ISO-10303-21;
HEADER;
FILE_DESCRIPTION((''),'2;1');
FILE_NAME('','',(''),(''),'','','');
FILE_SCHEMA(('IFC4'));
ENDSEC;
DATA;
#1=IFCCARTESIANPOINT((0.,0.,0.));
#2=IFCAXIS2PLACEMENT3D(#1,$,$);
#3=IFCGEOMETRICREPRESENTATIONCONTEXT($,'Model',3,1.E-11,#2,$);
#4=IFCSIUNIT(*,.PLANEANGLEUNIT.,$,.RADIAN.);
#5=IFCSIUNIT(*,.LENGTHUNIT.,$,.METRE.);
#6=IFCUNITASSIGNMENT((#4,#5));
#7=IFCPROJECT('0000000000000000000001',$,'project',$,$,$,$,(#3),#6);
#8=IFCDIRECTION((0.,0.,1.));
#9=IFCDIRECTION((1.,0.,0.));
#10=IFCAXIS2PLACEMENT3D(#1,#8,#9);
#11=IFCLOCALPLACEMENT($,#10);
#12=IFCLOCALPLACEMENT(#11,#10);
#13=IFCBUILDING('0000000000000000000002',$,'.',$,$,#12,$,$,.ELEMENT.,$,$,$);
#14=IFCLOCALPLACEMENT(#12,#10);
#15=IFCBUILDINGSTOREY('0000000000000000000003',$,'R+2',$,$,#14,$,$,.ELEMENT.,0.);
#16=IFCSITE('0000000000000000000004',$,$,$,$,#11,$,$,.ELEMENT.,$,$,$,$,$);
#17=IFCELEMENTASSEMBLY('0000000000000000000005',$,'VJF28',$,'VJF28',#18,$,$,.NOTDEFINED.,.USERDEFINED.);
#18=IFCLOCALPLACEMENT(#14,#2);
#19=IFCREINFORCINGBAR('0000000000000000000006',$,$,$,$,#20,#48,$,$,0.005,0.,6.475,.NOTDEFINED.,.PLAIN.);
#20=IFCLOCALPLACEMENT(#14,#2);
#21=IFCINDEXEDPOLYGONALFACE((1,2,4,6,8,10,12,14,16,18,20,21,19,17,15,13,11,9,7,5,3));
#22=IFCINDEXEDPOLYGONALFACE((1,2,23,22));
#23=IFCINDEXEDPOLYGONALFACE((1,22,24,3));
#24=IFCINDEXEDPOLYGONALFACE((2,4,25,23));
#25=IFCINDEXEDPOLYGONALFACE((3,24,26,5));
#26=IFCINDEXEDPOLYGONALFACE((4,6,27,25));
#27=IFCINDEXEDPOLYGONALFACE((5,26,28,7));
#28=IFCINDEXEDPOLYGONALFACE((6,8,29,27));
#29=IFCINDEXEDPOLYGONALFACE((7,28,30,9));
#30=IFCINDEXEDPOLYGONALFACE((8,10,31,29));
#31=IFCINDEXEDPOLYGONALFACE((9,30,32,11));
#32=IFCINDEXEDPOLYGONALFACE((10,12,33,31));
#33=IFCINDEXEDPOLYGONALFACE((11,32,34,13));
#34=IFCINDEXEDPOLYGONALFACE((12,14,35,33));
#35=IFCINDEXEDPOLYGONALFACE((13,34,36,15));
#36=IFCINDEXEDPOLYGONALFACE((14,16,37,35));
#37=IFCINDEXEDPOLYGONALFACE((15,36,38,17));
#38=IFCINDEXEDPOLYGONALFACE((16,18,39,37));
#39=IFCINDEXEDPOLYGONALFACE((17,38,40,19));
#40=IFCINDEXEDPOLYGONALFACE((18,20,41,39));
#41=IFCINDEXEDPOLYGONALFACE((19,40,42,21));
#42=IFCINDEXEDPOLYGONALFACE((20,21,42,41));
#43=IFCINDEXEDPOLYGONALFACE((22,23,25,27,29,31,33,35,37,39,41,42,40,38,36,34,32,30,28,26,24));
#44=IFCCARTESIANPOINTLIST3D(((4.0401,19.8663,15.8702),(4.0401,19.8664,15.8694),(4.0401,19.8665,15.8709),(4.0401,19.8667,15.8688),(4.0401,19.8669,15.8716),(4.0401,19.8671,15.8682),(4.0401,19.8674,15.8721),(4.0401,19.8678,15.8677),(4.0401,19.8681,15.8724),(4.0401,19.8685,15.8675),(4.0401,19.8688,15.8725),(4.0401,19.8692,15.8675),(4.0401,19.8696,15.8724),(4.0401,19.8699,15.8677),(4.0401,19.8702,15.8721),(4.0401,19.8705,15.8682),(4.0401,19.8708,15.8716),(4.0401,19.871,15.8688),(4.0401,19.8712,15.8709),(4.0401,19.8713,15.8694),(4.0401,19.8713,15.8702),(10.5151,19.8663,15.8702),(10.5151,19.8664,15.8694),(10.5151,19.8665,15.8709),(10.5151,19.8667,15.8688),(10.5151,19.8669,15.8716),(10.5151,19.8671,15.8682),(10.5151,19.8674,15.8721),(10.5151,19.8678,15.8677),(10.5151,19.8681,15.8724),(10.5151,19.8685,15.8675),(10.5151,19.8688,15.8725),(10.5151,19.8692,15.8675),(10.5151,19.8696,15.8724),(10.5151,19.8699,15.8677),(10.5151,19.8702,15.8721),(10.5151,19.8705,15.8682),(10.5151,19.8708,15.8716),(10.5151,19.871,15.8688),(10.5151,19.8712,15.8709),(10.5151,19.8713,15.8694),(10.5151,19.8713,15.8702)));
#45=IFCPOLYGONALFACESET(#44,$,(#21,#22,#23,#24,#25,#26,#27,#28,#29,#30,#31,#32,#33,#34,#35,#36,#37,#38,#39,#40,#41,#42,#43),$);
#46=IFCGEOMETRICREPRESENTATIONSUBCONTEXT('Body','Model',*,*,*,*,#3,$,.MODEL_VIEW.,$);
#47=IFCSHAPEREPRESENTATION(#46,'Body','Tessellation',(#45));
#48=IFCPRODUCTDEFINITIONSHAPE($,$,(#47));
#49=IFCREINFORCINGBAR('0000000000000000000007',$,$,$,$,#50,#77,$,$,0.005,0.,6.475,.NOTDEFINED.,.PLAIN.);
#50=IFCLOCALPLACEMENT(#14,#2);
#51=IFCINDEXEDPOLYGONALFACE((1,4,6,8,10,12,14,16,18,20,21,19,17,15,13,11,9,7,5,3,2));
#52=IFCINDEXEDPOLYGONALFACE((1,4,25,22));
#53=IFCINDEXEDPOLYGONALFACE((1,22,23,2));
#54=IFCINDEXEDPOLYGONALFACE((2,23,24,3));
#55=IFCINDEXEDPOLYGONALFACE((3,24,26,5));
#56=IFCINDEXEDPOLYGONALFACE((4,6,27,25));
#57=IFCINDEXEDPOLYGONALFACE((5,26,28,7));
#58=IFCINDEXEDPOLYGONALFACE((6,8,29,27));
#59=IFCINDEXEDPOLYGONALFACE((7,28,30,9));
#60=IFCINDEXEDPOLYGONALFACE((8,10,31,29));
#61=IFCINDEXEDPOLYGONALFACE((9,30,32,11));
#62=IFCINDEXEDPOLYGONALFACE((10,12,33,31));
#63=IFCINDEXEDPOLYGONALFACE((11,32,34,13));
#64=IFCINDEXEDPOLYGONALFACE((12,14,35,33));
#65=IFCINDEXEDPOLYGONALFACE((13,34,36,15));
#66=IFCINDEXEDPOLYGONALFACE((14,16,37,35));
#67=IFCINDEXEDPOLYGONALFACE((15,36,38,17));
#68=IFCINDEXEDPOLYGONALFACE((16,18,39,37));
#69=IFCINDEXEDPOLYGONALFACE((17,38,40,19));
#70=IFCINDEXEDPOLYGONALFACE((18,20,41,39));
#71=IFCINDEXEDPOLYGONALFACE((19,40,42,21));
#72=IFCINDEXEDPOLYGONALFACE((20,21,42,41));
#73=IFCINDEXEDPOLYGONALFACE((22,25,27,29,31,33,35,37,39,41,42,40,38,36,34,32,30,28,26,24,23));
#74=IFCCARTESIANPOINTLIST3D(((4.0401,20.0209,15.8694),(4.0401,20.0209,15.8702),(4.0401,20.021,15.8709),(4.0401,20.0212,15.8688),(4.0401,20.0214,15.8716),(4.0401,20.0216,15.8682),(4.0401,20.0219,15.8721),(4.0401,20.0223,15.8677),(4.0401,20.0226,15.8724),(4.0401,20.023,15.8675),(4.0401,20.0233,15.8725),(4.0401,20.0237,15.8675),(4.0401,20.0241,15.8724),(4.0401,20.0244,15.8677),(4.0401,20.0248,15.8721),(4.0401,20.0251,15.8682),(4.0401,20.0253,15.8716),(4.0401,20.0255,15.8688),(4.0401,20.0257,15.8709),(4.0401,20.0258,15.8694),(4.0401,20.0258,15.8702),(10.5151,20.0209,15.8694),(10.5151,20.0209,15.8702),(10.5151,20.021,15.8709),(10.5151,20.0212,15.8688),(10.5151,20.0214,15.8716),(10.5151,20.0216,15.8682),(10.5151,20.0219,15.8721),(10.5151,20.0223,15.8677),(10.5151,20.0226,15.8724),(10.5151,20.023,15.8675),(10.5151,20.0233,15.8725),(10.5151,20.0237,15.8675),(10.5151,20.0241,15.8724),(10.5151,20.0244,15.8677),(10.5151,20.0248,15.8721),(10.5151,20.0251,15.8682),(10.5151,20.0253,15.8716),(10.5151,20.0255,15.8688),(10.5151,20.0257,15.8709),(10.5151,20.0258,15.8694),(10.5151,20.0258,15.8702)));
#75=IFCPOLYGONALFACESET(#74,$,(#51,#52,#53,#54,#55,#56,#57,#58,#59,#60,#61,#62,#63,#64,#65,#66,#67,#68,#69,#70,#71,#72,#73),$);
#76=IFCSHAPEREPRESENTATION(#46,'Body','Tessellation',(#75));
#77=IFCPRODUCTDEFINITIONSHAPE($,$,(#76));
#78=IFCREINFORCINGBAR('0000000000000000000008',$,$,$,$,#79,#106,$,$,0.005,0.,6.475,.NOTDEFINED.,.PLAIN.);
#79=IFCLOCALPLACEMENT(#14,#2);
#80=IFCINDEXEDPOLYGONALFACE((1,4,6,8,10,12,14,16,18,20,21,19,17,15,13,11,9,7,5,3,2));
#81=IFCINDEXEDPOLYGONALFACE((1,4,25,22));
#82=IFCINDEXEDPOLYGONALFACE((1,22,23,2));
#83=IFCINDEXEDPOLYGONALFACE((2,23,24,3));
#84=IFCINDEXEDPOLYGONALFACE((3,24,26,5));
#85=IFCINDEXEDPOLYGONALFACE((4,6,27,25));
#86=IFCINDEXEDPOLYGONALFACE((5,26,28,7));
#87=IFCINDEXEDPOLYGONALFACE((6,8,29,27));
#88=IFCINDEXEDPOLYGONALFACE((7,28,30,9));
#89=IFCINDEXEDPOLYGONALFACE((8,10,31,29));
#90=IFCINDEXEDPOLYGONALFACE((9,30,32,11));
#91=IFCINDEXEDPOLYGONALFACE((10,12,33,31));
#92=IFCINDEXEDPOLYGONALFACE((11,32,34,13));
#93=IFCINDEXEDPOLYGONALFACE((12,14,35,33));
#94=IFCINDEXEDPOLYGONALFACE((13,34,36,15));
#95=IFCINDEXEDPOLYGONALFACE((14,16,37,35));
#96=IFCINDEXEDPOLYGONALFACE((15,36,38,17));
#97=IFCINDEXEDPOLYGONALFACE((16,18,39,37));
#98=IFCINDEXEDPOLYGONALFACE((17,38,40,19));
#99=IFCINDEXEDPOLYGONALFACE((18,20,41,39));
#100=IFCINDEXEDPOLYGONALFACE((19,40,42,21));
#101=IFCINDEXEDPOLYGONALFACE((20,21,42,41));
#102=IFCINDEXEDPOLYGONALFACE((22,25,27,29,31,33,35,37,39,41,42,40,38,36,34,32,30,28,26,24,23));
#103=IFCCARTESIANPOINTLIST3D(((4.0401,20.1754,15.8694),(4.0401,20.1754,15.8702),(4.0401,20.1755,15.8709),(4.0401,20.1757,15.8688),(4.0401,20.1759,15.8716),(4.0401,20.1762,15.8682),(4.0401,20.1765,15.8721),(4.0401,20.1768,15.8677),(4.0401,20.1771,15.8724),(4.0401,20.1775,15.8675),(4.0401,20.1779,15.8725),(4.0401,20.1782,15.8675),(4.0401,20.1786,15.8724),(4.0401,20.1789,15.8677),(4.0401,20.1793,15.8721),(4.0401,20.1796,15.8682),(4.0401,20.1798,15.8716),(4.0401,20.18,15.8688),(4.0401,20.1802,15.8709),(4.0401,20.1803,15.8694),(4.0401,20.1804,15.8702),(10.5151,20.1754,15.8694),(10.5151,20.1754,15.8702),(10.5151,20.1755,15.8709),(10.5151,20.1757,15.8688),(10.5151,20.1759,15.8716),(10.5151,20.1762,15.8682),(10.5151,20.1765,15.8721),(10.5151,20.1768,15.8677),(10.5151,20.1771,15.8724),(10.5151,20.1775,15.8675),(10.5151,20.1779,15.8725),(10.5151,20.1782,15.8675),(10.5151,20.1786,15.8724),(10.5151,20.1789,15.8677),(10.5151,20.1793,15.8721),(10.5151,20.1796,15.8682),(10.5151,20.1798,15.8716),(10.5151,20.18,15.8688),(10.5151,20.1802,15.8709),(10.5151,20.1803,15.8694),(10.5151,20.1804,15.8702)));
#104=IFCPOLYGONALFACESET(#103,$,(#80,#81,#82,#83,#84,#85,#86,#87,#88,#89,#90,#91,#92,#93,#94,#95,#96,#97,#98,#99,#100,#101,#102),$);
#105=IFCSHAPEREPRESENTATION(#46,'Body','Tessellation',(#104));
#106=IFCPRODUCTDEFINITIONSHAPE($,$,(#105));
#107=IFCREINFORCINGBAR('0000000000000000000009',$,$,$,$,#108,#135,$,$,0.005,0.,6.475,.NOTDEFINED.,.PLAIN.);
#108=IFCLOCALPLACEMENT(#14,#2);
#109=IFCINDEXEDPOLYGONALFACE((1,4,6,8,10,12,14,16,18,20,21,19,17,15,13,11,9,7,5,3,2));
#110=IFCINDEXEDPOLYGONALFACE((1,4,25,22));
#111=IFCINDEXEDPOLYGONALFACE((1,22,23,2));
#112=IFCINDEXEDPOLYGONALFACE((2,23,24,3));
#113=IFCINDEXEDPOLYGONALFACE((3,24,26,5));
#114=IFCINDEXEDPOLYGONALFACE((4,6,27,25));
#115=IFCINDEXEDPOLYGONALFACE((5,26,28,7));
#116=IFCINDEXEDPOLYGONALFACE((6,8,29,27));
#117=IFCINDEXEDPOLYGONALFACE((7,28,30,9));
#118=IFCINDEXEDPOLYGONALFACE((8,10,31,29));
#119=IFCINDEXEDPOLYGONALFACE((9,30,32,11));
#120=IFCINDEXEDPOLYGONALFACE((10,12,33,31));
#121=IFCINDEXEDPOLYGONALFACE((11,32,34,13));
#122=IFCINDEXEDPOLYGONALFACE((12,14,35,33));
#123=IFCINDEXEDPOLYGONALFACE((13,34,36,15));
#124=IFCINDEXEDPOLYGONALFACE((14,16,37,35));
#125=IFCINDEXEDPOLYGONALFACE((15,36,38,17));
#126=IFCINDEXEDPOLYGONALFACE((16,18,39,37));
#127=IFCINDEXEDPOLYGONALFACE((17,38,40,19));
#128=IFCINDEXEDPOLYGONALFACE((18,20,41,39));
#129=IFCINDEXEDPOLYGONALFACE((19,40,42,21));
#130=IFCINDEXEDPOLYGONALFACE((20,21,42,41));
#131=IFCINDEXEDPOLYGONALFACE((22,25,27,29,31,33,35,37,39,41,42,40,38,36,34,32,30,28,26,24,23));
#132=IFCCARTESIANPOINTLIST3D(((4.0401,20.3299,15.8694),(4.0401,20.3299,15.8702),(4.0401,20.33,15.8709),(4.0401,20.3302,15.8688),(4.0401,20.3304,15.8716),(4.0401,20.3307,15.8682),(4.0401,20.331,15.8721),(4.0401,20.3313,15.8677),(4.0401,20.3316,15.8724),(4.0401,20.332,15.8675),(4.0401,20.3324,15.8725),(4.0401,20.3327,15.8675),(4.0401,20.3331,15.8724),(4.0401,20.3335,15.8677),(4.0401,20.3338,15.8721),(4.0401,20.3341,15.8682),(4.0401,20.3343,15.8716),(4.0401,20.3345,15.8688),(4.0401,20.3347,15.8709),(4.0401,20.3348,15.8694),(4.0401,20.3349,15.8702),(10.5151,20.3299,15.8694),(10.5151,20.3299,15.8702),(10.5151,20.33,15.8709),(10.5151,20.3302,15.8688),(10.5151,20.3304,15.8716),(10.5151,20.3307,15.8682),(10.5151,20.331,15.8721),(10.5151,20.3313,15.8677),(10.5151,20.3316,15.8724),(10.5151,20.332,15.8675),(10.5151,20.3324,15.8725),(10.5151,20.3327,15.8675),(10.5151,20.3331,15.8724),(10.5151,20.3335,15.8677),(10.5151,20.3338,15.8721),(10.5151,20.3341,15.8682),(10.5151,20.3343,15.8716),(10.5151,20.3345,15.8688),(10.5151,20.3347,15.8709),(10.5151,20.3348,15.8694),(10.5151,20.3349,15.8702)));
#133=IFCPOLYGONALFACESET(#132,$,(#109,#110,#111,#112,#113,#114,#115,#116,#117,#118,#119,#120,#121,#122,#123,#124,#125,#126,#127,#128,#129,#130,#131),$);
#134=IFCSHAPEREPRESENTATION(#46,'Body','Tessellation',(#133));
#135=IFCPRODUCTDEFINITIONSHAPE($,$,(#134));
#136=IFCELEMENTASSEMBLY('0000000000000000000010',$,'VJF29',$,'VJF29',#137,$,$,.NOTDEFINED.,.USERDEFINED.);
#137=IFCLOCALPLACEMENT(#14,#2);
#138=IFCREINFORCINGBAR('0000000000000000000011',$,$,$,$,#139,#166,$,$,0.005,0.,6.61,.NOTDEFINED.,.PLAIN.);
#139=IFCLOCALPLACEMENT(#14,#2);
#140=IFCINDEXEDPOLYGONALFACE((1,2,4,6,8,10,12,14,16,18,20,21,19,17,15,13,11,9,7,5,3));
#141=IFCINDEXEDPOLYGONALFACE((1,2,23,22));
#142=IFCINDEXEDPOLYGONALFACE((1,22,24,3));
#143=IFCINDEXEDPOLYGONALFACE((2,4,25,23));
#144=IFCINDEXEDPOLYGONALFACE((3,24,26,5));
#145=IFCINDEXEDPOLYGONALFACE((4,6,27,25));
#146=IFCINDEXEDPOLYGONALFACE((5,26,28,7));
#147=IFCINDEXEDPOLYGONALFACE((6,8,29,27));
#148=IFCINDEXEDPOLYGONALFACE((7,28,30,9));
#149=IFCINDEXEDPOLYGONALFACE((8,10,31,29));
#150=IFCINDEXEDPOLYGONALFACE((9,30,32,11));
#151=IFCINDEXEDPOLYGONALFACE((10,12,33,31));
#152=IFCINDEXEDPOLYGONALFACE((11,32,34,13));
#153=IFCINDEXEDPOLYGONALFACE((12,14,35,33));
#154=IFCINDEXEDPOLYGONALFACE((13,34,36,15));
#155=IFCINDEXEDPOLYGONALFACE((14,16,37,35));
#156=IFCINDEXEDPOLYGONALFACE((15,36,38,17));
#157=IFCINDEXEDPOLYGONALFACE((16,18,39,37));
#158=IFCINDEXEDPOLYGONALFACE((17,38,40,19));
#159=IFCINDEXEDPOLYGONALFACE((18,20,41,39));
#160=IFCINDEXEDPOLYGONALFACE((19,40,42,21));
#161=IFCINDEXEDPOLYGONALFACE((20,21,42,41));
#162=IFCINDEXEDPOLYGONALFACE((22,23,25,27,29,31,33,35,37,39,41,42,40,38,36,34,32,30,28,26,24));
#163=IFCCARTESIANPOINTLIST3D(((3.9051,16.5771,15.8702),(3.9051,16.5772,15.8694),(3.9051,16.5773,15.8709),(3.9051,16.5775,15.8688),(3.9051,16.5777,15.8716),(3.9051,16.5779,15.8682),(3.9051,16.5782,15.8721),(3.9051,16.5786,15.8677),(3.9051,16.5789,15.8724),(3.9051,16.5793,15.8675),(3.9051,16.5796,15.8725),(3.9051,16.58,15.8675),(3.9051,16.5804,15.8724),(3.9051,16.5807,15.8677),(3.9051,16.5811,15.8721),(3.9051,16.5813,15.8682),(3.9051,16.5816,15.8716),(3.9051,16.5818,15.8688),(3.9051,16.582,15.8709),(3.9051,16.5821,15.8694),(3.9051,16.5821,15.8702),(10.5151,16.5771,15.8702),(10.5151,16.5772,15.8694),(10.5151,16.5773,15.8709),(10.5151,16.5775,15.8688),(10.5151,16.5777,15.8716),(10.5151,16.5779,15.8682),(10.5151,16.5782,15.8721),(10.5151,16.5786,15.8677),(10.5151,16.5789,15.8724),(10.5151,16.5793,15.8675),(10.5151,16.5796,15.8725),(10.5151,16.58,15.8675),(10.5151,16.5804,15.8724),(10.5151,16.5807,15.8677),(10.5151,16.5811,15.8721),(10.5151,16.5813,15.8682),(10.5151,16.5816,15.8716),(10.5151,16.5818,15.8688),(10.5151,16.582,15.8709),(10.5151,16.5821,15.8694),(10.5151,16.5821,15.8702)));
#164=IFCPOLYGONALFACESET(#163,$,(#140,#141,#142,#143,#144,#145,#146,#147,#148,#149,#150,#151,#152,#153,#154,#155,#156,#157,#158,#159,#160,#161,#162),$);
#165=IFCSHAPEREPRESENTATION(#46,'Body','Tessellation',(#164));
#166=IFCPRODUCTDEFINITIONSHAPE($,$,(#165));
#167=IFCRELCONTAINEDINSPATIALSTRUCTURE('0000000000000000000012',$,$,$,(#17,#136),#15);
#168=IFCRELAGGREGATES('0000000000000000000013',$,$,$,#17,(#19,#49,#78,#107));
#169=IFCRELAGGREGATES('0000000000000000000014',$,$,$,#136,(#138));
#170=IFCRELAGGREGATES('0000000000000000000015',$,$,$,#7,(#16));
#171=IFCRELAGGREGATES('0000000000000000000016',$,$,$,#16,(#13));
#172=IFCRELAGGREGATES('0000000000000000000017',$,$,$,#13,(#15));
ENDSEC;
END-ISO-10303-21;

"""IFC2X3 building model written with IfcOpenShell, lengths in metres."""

from ifc_helpers import new_model, entity, si_unit, origin, origin_with_axes, place, context, subcontext, project, spatial, shape, element, aggregate, save


model = new_model("IFC2X3")

# Units and contexts
model_context = context("Model", 3, precision=1e-11, world=origin())
body_context = subcontext(model_context, "Body", "Model", "MODEL_VIEW")
ifc_project = project(units=[si_unit("PLANEANGLEUNIT", "RADIAN"), si_unit("LENGTHUNIT", "METRE")], contexts=[model_context])

# Site, building, storey
site_placement = place(None, origin_with_axes())
site = spatial("IfcSite", under=ifc_project, at=site_placement, CompositionType="ELEMENT")
building_placement = place(site_placement, origin_with_axes())
building = spatial("IfcBuilding", under=site, at=building_placement, Name=".", CompositionType="ELEMENT")
storey_placement = place(building_placement, origin_with_axes())
storey = spatial("IfcBuildingStorey", under=building, at=storey_placement, Name="R+2", CompositionType="ELEMENT", Elevation=0.0)

# Element assemblies, reinforcing bars
assembly_1_placement = place(storey_placement, origin_with_axes())
assembly_1 = element("IfcElementAssembly", 1, at=assembly_1_placement, inside=storey, Name="VJF28", ObjectType="VJF28", AssemblyPlace="NOTDEFINED", PredefinedType="USERDEFINED")
reinforcing_bar_1_placement = place(assembly_1_placement, origin_with_axes())
reinforcing_bar_1 = element("IfcReinforcingBar", 2, at=reinforcing_bar_1_placement, BarLength=6.475, BarRole="NOTDEFINED", BarSurface="PLAIN", CrossSectionArea=0.0, NominalDiameter=0.005, shapes=[
    shape(body_context, "Body", "AdvancedSweptSolid", [entity("IfcSweptDiskSolid", entity("IfcPolyline", [entity("IfcCartesianPoint", [4.0401, 19.8688, 15.87]), entity("IfcCartesianPoint", [10.5151, 19.8688, 15.87])]), 0.0025, None, 0.0, 6.475)]),
    shape(body_context, "Body", "AdvancedSweptSolid", [entity("IfcSweptDiskSolid", entity("IfcPolyline", [entity("IfcCartesianPoint", [4.0401, 19.8688, 15.87]), entity("IfcCartesianPoint", [10.5151, 19.8688, 15.87])]), 0.0025, None, 0.0, 6.475)]),
])
reinforcing_bar_2_placement = place(assembly_1_placement, origin_with_axes())
reinforcing_bar_2 = element("IfcReinforcingBar", 3, at=reinforcing_bar_2_placement, BarLength=6.475, BarRole="NOTDEFINED", BarSurface="PLAIN", CrossSectionArea=0.0, NominalDiameter=0.005, shapes=[
    shape(body_context, "Body", "AdvancedSweptSolid", [entity("IfcSweptDiskSolid", entity("IfcPolyline", [entity("IfcCartesianPoint", [4.0401, 20.0233, 15.87]), entity("IfcCartesianPoint", [10.5151, 20.0233, 15.87])]), 0.0025, None, 0.0, 6.475)]),
    shape(body_context, "Body", "AdvancedSweptSolid", [entity("IfcSweptDiskSolid", entity("IfcPolyline", [entity("IfcCartesianPoint", [4.0401, 20.0233, 15.87]), entity("IfcCartesianPoint", [10.5151, 20.0233, 15.87])]), 0.0025, None, 0.0, 6.475)]),
])
reinforcing_bar_3_placement = place(assembly_1_placement, origin_with_axes())
reinforcing_bar_3 = element("IfcReinforcingBar", 4, at=reinforcing_bar_3_placement, BarLength=6.475, BarRole="NOTDEFINED", BarSurface="PLAIN", CrossSectionArea=0.0, NominalDiameter=0.005, shapes=[
    shape(body_context, "Body", "AdvancedSweptSolid", [entity("IfcSweptDiskSolid", entity("IfcPolyline", [entity("IfcCartesianPoint", [4.0401, 20.1779, 15.87]), entity("IfcCartesianPoint", [10.5151, 20.1779, 15.87])]), 0.0025, None, 0.0, 6.475)]),
    shape(body_context, "Body", "AdvancedSweptSolid", [entity("IfcSweptDiskSolid", entity("IfcPolyline", [entity("IfcCartesianPoint", [4.0401, 20.1779, 15.87]), entity("IfcCartesianPoint", [10.5151, 20.1779, 15.87])]), 0.0025, None, 0.0, 6.475)]),
])
reinforcing_bar_4_placement = place(assembly_1_placement, origin_with_axes())
reinforcing_bar_4 = element("IfcReinforcingBar", 5, at=reinforcing_bar_4_placement, BarLength=6.475, BarRole="NOTDEFINED", BarSurface="PLAIN", CrossSectionArea=0.0, NominalDiameter=0.005, shapes=[
    shape(body_context, "Body", "AdvancedSweptSolid", [entity("IfcSweptDiskSolid", entity("IfcPolyline", [entity("IfcCartesianPoint", [4.0401, 20.3324, 15.87]), entity("IfcCartesianPoint", [10.5151, 20.3324, 15.87])]), 0.0025, None, 0.0, 6.475)]),
    shape(body_context, "Body", "AdvancedSweptSolid", [entity("IfcSweptDiskSolid", entity("IfcPolyline", [entity("IfcCartesianPoint", [4.0401, 20.3324, 15.87]), entity("IfcCartesianPoint", [10.5151, 20.3324, 15.87])]), 0.0025, None, 0.0, 6.475)]),
])
aggregate(assembly_1, [reinforcing_bar_1, reinforcing_bar_2, reinforcing_bar_3, reinforcing_bar_4])
assembly_2_placement = place(storey_placement, origin_with_axes())
assembly_2 = element("IfcElementAssembly", 6, at=assembly_2_placement, inside=storey, Name="VJF29", ObjectType="VJF29", AssemblyPlace="NOTDEFINED", PredefinedType="USERDEFINED")
reinforcing_bar_5_placement = place(assembly_2_placement, origin_with_axes())
reinforcing_bar_5 = element("IfcReinforcingBar", 7, at=reinforcing_bar_5_placement, BarLength=6.61, BarRole="NOTDEFINED", BarSurface="PLAIN", CrossSectionArea=0.0, NominalDiameter=0.005, shapes=[
    shape(body_context, "Body", "AdvancedSweptSolid", [entity("IfcSweptDiskSolid", entity("IfcPolyline", [entity("IfcCartesianPoint", [3.9051, 16.5796, 15.87]), entity("IfcCartesianPoint", [10.5151, 16.5796, 15.87])]), 0.0025, None, 0.0, 6.61)]),
    shape(body_context, "Body", "AdvancedSweptSolid", [entity("IfcSweptDiskSolid", entity("IfcPolyline", [entity("IfcCartesianPoint", [3.9051, 16.5796, 15.87]), entity("IfcCartesianPoint", [10.5151, 16.5796, 15.87])]), 0.0025, None, 0.0, 6.61)]),
])
aggregate(assembly_2, [reinforcing_bar_5])

save(model, "model.ifc")
